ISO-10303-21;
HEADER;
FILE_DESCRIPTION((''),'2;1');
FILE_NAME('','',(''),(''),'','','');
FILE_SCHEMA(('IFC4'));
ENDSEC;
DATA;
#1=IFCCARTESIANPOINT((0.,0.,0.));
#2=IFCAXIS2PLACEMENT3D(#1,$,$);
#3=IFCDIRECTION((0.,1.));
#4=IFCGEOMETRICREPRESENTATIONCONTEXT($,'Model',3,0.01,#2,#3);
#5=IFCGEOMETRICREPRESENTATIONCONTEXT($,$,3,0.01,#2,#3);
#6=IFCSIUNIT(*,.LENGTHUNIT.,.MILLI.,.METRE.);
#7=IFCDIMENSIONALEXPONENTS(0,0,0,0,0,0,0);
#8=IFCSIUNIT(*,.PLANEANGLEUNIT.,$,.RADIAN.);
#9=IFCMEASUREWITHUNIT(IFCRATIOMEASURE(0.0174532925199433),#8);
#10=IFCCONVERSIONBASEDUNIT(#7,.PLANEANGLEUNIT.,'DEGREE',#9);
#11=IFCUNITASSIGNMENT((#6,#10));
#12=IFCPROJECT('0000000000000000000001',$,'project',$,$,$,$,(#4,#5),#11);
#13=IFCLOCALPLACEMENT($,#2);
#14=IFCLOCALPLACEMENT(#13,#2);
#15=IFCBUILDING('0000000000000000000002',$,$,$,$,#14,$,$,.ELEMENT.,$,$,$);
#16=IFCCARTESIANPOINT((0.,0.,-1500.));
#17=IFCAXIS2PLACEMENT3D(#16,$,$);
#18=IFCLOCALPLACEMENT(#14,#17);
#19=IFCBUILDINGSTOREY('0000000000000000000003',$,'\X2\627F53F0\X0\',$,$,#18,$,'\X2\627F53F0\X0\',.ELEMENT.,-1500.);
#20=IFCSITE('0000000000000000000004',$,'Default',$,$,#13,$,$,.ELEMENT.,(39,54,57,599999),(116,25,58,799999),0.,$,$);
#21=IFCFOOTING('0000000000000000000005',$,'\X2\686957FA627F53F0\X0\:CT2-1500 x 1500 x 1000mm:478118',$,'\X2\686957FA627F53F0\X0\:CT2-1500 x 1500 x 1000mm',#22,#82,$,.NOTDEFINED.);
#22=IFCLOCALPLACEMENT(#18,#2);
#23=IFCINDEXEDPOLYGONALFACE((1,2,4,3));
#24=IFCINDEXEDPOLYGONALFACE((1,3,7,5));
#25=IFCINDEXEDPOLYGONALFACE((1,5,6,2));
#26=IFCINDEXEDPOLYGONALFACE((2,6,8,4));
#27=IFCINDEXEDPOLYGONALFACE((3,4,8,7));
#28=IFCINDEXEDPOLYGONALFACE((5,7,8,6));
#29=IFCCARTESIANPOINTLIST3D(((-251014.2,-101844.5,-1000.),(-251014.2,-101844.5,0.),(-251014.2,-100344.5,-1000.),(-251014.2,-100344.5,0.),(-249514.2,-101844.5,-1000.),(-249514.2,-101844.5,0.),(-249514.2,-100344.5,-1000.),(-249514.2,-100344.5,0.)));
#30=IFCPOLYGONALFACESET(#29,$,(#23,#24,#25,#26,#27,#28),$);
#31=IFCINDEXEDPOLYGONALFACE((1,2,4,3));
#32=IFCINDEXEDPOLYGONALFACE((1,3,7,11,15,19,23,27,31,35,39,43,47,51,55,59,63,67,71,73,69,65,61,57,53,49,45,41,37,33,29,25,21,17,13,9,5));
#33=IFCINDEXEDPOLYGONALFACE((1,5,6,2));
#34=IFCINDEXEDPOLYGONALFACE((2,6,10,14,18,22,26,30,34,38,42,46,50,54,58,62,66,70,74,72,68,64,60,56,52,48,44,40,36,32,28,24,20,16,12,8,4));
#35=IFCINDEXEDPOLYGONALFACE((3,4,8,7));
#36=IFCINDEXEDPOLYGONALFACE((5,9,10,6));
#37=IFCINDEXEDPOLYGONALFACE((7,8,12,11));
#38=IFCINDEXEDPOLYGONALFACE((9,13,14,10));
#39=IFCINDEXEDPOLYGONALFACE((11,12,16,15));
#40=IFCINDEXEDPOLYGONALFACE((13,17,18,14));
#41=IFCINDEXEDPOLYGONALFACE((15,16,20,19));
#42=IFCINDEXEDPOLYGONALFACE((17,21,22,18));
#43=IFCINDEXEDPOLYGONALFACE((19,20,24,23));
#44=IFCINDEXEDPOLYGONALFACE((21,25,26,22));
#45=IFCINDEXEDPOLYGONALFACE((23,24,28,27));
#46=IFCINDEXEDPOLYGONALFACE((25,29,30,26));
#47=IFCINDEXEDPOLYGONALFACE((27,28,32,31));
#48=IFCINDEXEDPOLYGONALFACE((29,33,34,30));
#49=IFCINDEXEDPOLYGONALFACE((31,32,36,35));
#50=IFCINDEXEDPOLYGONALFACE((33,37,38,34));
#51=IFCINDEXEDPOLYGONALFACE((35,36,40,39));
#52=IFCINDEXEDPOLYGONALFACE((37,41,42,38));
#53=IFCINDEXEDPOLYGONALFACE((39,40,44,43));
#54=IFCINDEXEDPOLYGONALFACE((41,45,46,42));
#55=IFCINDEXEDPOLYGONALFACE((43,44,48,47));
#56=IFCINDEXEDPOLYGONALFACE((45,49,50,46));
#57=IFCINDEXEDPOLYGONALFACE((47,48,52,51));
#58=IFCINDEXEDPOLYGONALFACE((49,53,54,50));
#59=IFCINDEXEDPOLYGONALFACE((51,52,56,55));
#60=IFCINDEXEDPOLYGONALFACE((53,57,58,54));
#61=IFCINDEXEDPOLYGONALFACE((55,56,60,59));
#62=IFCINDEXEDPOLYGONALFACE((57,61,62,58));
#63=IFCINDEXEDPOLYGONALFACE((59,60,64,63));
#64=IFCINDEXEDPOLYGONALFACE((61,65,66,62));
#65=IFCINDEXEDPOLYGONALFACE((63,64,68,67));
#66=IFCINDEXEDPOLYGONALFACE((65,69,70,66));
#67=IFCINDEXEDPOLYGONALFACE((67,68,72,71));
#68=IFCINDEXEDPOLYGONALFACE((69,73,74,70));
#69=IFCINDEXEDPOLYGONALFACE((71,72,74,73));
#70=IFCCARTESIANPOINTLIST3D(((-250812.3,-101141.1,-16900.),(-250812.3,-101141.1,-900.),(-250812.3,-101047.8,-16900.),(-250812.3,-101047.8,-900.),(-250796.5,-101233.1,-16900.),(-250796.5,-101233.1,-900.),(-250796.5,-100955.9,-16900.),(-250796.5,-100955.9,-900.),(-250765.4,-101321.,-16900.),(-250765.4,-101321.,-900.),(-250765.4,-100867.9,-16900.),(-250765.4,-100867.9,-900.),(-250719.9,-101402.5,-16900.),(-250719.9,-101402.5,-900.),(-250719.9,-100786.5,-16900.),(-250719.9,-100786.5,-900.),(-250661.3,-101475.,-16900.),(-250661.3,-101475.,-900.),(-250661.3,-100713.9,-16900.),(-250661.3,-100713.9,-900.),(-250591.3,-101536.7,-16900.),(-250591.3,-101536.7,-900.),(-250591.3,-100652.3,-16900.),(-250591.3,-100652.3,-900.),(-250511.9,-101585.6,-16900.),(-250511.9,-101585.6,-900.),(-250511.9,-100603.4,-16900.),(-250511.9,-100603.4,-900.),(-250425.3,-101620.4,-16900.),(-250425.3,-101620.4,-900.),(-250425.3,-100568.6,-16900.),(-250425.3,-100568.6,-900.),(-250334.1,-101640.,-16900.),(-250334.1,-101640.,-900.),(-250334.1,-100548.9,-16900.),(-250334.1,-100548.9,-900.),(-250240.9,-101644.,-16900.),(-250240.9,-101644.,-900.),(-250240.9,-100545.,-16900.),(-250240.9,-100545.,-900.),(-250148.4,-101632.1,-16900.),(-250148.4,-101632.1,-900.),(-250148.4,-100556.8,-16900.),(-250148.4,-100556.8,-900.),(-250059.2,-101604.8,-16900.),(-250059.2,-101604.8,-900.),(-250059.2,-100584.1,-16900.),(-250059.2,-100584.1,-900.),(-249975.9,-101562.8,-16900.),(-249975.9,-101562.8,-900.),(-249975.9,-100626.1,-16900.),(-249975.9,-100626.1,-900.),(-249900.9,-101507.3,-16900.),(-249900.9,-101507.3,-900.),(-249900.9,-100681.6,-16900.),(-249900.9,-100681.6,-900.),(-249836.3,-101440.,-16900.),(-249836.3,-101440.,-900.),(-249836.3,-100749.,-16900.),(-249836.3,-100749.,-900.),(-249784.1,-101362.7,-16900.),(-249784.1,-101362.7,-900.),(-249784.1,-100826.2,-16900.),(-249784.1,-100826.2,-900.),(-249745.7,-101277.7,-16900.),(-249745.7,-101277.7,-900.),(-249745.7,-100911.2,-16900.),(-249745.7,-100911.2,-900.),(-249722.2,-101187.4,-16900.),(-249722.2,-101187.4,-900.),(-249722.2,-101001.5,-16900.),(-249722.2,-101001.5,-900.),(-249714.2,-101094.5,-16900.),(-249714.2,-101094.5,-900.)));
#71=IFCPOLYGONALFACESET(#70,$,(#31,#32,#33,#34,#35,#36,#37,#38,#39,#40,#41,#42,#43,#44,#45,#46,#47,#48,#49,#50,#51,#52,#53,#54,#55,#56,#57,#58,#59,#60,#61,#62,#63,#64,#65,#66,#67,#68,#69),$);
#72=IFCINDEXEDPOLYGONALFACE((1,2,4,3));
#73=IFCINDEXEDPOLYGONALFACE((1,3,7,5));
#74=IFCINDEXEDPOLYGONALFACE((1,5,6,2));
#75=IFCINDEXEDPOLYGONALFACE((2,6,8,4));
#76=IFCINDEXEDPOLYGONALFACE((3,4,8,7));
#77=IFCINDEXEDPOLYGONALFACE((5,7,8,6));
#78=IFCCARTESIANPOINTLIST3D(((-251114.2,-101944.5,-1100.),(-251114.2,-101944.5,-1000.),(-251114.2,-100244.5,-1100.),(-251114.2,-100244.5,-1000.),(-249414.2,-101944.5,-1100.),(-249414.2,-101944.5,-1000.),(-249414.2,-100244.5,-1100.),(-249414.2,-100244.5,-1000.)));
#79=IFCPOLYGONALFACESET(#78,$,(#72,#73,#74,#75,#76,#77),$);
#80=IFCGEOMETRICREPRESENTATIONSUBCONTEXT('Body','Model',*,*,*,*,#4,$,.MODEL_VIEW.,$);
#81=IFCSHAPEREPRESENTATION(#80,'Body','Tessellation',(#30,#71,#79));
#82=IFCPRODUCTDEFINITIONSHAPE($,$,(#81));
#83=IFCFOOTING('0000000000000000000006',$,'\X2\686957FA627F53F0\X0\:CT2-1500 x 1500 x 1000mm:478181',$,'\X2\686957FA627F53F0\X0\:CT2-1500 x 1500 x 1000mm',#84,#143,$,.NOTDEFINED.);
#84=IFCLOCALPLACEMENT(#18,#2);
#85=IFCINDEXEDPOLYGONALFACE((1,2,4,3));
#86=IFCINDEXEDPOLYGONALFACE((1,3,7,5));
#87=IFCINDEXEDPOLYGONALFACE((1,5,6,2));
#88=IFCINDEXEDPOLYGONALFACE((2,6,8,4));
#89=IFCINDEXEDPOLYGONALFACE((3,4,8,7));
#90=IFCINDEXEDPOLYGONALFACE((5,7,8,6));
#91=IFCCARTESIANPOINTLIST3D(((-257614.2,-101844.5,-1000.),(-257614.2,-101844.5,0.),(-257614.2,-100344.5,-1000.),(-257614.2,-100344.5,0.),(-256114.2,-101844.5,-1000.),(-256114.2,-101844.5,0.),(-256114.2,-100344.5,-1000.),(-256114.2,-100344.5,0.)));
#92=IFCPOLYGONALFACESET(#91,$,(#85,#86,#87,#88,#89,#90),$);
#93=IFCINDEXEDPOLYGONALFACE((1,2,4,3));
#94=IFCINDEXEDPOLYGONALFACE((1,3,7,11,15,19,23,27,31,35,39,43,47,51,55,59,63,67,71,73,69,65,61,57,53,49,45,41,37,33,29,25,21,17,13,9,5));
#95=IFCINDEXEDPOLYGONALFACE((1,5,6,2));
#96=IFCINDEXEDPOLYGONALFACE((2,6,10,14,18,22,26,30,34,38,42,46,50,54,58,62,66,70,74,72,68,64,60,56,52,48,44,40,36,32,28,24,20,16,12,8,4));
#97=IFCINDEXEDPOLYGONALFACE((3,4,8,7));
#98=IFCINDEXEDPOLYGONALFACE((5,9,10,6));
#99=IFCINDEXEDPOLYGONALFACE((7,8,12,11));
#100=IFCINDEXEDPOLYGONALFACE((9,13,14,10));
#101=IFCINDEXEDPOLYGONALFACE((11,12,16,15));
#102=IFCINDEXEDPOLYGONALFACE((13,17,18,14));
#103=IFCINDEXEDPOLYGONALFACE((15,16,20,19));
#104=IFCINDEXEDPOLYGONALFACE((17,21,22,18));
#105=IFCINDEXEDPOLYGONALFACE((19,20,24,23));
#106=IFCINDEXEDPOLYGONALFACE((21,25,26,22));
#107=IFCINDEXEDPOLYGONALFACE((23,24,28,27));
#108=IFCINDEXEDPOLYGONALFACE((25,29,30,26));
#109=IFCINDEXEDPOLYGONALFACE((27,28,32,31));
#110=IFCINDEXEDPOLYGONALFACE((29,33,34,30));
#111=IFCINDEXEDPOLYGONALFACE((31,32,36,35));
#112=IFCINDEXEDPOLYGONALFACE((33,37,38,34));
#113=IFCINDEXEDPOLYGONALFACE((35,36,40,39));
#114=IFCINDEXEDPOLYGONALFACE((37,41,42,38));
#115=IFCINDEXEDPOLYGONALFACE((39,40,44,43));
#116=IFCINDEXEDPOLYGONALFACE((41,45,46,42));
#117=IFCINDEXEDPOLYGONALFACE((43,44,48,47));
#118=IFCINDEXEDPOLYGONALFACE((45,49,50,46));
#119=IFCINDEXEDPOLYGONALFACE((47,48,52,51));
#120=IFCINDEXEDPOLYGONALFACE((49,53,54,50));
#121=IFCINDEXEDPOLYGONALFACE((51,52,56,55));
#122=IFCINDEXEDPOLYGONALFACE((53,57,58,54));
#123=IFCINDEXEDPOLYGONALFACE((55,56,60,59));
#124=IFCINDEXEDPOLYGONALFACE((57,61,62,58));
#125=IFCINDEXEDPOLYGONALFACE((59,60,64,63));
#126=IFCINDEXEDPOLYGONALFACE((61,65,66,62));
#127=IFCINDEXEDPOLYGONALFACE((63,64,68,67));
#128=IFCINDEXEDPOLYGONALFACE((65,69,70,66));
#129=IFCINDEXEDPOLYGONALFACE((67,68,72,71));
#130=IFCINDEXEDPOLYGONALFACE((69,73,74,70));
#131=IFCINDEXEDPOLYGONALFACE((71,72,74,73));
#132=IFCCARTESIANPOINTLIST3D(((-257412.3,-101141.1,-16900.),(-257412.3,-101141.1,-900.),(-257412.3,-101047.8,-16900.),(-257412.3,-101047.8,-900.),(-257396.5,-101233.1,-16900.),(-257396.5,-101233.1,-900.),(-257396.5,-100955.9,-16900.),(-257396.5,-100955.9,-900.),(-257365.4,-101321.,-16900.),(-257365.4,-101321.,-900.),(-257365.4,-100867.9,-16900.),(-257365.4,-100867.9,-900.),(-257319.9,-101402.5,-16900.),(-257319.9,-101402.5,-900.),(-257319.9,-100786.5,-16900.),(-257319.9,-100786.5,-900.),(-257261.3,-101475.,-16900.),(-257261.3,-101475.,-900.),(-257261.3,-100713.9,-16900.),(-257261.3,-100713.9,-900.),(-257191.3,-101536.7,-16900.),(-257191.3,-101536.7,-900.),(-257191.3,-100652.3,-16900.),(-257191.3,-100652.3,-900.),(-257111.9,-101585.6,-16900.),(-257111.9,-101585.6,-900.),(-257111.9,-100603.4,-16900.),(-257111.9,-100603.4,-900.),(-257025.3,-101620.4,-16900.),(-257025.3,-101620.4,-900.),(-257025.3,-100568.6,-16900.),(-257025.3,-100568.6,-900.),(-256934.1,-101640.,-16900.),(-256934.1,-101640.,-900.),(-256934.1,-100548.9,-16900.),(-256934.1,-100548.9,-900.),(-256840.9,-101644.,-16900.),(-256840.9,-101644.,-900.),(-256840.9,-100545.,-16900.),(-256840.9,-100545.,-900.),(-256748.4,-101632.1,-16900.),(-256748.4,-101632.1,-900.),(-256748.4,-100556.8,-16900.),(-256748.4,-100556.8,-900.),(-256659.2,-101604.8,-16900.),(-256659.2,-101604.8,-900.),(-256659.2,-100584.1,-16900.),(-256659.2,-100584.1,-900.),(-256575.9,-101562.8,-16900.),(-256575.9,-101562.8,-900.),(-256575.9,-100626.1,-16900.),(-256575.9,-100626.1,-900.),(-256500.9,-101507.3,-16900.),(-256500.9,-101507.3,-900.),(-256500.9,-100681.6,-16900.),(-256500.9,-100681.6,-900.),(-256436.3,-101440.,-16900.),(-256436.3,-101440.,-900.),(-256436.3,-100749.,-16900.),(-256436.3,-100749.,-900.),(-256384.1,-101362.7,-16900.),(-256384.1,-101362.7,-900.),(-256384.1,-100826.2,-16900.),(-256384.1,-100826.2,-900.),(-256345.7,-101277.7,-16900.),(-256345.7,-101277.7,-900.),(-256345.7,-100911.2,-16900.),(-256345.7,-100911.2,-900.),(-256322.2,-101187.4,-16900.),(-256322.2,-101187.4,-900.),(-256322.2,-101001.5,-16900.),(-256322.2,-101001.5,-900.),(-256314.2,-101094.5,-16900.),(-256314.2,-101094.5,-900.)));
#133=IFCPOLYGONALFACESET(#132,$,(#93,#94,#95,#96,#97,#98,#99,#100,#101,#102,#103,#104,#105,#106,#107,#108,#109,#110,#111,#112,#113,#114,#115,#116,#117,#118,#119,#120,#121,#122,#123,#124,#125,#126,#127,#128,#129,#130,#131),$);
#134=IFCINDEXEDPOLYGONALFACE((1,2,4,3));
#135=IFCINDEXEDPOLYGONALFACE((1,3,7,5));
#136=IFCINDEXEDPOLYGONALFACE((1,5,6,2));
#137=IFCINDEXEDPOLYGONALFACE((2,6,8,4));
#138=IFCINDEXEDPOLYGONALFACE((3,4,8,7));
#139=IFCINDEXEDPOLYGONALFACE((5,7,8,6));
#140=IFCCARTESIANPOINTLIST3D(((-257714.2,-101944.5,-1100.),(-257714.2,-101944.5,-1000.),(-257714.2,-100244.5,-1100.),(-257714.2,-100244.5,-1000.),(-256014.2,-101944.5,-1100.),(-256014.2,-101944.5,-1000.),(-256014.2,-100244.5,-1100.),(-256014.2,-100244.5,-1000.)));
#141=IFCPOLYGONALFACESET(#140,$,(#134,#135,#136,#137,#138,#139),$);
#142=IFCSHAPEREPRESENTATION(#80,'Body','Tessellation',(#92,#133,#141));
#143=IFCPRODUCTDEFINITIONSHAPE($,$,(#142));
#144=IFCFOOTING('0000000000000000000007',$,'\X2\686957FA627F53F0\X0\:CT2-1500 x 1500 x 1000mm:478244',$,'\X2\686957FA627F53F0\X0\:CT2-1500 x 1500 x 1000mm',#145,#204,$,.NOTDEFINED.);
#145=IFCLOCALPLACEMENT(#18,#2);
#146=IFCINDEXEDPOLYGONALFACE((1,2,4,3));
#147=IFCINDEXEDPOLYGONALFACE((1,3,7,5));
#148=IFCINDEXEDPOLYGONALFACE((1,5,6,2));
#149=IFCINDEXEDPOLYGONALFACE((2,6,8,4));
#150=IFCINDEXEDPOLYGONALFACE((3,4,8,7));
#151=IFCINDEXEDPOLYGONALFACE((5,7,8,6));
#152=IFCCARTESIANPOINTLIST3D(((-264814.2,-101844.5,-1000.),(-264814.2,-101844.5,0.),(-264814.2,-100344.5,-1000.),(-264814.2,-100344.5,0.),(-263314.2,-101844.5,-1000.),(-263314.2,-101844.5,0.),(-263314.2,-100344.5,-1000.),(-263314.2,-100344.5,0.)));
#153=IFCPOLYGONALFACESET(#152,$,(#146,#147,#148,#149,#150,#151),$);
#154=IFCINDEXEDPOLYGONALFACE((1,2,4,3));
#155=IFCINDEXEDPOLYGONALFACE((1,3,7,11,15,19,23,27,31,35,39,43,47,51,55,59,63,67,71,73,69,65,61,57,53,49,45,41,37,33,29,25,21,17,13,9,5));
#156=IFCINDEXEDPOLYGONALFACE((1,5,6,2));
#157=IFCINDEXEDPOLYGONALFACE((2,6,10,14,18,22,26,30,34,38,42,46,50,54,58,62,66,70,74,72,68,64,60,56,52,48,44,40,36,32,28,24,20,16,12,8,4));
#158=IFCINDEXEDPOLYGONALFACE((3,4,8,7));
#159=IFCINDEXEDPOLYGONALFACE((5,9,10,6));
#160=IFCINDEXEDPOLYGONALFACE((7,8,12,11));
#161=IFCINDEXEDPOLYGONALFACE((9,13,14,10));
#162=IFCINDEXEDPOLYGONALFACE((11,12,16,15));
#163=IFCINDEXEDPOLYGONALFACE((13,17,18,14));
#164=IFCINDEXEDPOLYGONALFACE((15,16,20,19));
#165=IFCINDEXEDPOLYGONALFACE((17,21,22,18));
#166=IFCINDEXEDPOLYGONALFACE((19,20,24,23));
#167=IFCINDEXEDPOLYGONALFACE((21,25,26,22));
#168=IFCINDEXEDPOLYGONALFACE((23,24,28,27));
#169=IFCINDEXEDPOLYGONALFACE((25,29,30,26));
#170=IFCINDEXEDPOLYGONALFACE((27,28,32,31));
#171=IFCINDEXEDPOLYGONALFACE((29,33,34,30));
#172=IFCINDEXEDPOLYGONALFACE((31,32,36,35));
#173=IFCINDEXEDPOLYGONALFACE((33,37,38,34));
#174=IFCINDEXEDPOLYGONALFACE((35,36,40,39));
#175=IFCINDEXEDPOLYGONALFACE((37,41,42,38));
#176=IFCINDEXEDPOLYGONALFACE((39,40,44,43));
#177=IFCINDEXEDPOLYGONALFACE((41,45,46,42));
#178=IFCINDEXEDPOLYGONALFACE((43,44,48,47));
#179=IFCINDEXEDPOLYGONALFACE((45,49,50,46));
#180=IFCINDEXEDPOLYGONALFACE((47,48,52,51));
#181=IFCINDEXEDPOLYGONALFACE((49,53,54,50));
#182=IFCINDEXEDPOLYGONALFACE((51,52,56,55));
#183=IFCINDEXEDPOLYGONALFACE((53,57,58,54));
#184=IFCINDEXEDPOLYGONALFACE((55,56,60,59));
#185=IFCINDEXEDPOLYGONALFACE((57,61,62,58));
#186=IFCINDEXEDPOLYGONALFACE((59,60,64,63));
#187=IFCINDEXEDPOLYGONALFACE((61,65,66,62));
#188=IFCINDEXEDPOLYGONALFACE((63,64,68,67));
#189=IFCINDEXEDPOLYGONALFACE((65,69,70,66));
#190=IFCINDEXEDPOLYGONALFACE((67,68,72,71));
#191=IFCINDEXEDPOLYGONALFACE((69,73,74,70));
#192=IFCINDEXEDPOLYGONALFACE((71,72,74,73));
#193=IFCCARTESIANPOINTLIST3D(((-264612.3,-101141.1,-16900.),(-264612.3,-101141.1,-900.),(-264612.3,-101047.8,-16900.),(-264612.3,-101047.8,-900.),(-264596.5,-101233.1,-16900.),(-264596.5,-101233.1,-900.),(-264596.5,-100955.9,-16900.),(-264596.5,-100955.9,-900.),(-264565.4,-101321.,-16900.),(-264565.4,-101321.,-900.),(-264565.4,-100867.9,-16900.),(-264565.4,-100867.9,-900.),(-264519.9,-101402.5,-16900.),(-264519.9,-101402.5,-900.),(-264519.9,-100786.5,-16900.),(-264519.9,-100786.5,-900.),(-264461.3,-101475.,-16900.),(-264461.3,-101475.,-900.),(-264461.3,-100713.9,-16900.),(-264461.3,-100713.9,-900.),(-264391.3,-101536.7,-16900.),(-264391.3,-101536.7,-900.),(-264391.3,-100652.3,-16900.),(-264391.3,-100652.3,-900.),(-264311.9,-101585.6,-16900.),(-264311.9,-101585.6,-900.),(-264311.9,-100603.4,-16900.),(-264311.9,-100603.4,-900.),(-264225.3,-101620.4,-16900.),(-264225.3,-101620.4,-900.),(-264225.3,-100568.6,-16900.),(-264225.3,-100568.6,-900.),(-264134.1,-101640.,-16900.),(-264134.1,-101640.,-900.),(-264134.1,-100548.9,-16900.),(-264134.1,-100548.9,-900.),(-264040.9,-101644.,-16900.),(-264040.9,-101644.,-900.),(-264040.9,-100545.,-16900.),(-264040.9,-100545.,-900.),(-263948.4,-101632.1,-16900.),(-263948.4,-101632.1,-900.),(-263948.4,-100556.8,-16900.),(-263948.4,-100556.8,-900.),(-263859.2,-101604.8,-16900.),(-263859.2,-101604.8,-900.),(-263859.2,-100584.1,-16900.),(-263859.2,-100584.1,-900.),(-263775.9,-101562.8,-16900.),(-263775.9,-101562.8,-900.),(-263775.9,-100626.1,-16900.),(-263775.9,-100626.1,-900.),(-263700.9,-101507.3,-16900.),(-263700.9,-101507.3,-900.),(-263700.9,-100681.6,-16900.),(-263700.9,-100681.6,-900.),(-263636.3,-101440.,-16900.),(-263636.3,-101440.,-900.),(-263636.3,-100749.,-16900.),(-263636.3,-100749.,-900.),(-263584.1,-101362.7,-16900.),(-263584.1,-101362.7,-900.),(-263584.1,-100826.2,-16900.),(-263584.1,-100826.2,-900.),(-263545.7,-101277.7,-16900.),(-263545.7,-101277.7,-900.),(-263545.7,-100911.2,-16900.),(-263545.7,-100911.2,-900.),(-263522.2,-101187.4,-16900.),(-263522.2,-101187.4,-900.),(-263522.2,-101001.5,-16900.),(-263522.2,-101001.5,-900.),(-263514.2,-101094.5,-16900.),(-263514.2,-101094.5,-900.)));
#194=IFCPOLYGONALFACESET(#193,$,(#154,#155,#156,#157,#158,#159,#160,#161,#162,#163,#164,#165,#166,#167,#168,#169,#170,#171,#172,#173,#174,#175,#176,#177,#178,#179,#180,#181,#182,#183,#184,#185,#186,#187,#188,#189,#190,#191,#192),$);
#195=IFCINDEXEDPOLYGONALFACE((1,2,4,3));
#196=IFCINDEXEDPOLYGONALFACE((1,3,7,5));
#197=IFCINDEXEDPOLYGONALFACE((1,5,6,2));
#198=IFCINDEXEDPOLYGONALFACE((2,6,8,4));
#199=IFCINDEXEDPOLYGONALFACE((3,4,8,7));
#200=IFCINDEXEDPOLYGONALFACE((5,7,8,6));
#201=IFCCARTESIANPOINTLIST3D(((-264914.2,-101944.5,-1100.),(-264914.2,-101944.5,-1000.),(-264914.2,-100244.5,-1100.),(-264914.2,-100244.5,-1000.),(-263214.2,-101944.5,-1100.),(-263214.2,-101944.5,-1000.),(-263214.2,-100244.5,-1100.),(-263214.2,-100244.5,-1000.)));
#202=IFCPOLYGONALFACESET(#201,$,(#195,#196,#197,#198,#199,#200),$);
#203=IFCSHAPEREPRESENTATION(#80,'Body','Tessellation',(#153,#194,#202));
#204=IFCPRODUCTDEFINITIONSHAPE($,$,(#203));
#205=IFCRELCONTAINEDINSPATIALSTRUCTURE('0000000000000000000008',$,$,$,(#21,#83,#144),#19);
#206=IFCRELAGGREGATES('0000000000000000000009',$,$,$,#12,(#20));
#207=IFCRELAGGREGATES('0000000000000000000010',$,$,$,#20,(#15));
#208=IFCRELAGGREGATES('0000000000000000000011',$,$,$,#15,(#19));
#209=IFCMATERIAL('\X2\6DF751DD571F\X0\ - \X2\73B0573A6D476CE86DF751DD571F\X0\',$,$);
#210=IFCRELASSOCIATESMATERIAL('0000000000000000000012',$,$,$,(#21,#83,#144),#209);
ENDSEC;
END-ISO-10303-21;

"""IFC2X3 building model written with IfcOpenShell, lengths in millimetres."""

from ifc_helpers import new_model, entity, si_unit, converted_unit, direction, frame, frame_2d, origin, origin_2d_with_axis, place, context, subcontext, project, spatial, rectangle, circle, extrude, material, element, save


model = new_model("IFC2X3")

# Units and contexts
model_context = context("Model", 3, precision=0.01, world=origin(), true_north=direction((0.0, 1.0)))
context_of_model = context(None, 3, precision=0.01, world=origin(), true_north=direction((0.0, 1.0)))
body_context = subcontext(model_context, "Body", "Model", "MODEL_VIEW")
ifc_project = project(units=[si_unit("LENGTHUNIT", "METRE", prefix="MILLI"), converted_unit("PLANEANGLEUNIT", "DEGREE", entity("IfcRatioMeasure", 0.0174532925199433), si_unit("PLANEANGLEUNIT", "RADIAN"), dimensions=[0, 0, 0, 0, 0, 0, 0])], contexts=[model_context, context_of_model])

# Site, building, storey
site_placement = place(None, origin())
site = spatial("IfcSite", under=ifc_project, at=site_placement, Name="Default", CompositionType="ELEMENT", RefLatitude=(39, 54, 57, 599999), RefLongitude=(116, 25, 58, 799999), RefElevation=0.0)
building_placement = place(site_placement, origin())
building = spatial("IfcBuilding", under=site, at=building_placement, CompositionType="ELEMENT")
storey_placement = place(building_placement, frame((0.0, 0.0, -1500.0)))
storey = spatial("IfcBuildingStorey", under=building, at=storey_placement, Name="承台", LongName="承台", CompositionType="ELEMENT", Elevation=-1500.0)

# Footings
ifc_material_1 = material(Name="混凝土 - 现场浇注混凝土")
footing_1_placement = place(storey_placement, frame((-251114.2, -101944.5, -16900.0)))
element("IfcFooting", 1, at=footing_1_placement, inside=storey, material=ifc_material_1, Name="桩基承台:CT2-1500 x 1500 x 1000mm:478118", ObjectType="桩基承台:CT2-1500 x 1500 x 1000mm", PredefinedType="NOTDEFINED", context=body_context, shape_type="SweptSolid", body=[
    extrude(rectangle(XDim=1500.0, YDim=1500.0, at=origin_2d_with_axis()), frame((850.0, 850.0, 15900.0), z_axis=(0.0, 0.0, 1.0), x_axis=(-1.0, 0.0, 0.0)), (0.0, 0.0, 1.0), 1000.0),
    extrude(circle(Radius=550.0, at=origin_2d_with_axis()), frame((850.0, 850.0, 0.0)), (0.0, 0.0, 1.0), 16000.0),
    extrude(rectangle(XDim=1700.0, YDim=1700.0, at=frame_2d((0.0, 0.0), x_axis=(1.0, 0.0))), frame((850.0, 850.0, 15800.0), z_axis=(0.0, 0.0, 1.0), x_axis=(0.0, 1.0, 0.0)), (0.0, 0.0, 1.0), 100.0),
])
footing_2_placement = place(storey_placement, frame((-257714.2, -101944.5, -16900.0)))
element("IfcFooting", 2, at=footing_2_placement, inside=storey, material=ifc_material_1, Name="桩基承台:CT2-1500 x 1500 x 1000mm:478181", ObjectType="桩基承台:CT2-1500 x 1500 x 1000mm", PredefinedType="NOTDEFINED", context=body_context, shape_type="SweptSolid", body=[
    extrude(rectangle(XDim=1500.0, YDim=1500.0, at=origin_2d_with_axis()), frame((850.0, 850.0, 15900.0), z_axis=(0.0, 0.0, 1.0), x_axis=(-1.0, 0.0, 0.0)), (0.0, 0.0, 1.0), 1000.0),
    extrude(circle(Radius=550.0, at=origin_2d_with_axis()), frame((850.0, 850.0, 0.0)), (0.0, 0.0, 1.0), 16000.0),
    extrude(rectangle(XDim=1700.0, YDim=1700.0, at=frame_2d((0.0, 0.0), x_axis=(1.0, 0.0))), frame((850.0, 850.0, 15800.0), z_axis=(0.0, 0.0, 1.0), x_axis=(0.0, 1.0, 0.0)), (0.0, 0.0, 1.0), 100.0),
])
for number, where, name in (
    (3, (-264914.2, -101944.5, -16900.0), "桩基承台:CT2-1500 x 1500 x 1000mm:478244"),
):
    element("IfcFooting", number, at=place(storey_placement, frame(where)), inside=storey, material=ifc_material_1, Name=name, ObjectType="桩基承台:CT2-1500 x 1500 x 1000mm", PredefinedType="NOTDEFINED", context=body_context, shape_type="SweptSolid", body=[
        extrude(rectangle(XDim=1500.0, YDim=1500.0, at=origin_2d_with_axis()), frame((850.0, 850.0, 15900.0), z_axis=(0.0, 0.0, 1.0), x_axis=(-1.0, 0.0, 0.0)), (0.0, 0.0, 1.0), 1000.0),
        extrude(circle(Radius=550.0, at=origin_2d_with_axis()), frame((850.0, 850.0, 0.0)), (0.0, 0.0, 1.0), 16000.0),
        extrude(rectangle(XDim=1700.0, YDim=1700.0, at=frame_2d((0.0, 0.0), x_axis=(1.0, 0.0))), frame((850.0, 850.0, 15800.0), z_axis=(0.0, 0.0, 1.0), x_axis=(0.0, 1.0, 0.0)), (0.0, 0.0, 1.0), 100.0),
    ])

save(model, "model.ifc")
